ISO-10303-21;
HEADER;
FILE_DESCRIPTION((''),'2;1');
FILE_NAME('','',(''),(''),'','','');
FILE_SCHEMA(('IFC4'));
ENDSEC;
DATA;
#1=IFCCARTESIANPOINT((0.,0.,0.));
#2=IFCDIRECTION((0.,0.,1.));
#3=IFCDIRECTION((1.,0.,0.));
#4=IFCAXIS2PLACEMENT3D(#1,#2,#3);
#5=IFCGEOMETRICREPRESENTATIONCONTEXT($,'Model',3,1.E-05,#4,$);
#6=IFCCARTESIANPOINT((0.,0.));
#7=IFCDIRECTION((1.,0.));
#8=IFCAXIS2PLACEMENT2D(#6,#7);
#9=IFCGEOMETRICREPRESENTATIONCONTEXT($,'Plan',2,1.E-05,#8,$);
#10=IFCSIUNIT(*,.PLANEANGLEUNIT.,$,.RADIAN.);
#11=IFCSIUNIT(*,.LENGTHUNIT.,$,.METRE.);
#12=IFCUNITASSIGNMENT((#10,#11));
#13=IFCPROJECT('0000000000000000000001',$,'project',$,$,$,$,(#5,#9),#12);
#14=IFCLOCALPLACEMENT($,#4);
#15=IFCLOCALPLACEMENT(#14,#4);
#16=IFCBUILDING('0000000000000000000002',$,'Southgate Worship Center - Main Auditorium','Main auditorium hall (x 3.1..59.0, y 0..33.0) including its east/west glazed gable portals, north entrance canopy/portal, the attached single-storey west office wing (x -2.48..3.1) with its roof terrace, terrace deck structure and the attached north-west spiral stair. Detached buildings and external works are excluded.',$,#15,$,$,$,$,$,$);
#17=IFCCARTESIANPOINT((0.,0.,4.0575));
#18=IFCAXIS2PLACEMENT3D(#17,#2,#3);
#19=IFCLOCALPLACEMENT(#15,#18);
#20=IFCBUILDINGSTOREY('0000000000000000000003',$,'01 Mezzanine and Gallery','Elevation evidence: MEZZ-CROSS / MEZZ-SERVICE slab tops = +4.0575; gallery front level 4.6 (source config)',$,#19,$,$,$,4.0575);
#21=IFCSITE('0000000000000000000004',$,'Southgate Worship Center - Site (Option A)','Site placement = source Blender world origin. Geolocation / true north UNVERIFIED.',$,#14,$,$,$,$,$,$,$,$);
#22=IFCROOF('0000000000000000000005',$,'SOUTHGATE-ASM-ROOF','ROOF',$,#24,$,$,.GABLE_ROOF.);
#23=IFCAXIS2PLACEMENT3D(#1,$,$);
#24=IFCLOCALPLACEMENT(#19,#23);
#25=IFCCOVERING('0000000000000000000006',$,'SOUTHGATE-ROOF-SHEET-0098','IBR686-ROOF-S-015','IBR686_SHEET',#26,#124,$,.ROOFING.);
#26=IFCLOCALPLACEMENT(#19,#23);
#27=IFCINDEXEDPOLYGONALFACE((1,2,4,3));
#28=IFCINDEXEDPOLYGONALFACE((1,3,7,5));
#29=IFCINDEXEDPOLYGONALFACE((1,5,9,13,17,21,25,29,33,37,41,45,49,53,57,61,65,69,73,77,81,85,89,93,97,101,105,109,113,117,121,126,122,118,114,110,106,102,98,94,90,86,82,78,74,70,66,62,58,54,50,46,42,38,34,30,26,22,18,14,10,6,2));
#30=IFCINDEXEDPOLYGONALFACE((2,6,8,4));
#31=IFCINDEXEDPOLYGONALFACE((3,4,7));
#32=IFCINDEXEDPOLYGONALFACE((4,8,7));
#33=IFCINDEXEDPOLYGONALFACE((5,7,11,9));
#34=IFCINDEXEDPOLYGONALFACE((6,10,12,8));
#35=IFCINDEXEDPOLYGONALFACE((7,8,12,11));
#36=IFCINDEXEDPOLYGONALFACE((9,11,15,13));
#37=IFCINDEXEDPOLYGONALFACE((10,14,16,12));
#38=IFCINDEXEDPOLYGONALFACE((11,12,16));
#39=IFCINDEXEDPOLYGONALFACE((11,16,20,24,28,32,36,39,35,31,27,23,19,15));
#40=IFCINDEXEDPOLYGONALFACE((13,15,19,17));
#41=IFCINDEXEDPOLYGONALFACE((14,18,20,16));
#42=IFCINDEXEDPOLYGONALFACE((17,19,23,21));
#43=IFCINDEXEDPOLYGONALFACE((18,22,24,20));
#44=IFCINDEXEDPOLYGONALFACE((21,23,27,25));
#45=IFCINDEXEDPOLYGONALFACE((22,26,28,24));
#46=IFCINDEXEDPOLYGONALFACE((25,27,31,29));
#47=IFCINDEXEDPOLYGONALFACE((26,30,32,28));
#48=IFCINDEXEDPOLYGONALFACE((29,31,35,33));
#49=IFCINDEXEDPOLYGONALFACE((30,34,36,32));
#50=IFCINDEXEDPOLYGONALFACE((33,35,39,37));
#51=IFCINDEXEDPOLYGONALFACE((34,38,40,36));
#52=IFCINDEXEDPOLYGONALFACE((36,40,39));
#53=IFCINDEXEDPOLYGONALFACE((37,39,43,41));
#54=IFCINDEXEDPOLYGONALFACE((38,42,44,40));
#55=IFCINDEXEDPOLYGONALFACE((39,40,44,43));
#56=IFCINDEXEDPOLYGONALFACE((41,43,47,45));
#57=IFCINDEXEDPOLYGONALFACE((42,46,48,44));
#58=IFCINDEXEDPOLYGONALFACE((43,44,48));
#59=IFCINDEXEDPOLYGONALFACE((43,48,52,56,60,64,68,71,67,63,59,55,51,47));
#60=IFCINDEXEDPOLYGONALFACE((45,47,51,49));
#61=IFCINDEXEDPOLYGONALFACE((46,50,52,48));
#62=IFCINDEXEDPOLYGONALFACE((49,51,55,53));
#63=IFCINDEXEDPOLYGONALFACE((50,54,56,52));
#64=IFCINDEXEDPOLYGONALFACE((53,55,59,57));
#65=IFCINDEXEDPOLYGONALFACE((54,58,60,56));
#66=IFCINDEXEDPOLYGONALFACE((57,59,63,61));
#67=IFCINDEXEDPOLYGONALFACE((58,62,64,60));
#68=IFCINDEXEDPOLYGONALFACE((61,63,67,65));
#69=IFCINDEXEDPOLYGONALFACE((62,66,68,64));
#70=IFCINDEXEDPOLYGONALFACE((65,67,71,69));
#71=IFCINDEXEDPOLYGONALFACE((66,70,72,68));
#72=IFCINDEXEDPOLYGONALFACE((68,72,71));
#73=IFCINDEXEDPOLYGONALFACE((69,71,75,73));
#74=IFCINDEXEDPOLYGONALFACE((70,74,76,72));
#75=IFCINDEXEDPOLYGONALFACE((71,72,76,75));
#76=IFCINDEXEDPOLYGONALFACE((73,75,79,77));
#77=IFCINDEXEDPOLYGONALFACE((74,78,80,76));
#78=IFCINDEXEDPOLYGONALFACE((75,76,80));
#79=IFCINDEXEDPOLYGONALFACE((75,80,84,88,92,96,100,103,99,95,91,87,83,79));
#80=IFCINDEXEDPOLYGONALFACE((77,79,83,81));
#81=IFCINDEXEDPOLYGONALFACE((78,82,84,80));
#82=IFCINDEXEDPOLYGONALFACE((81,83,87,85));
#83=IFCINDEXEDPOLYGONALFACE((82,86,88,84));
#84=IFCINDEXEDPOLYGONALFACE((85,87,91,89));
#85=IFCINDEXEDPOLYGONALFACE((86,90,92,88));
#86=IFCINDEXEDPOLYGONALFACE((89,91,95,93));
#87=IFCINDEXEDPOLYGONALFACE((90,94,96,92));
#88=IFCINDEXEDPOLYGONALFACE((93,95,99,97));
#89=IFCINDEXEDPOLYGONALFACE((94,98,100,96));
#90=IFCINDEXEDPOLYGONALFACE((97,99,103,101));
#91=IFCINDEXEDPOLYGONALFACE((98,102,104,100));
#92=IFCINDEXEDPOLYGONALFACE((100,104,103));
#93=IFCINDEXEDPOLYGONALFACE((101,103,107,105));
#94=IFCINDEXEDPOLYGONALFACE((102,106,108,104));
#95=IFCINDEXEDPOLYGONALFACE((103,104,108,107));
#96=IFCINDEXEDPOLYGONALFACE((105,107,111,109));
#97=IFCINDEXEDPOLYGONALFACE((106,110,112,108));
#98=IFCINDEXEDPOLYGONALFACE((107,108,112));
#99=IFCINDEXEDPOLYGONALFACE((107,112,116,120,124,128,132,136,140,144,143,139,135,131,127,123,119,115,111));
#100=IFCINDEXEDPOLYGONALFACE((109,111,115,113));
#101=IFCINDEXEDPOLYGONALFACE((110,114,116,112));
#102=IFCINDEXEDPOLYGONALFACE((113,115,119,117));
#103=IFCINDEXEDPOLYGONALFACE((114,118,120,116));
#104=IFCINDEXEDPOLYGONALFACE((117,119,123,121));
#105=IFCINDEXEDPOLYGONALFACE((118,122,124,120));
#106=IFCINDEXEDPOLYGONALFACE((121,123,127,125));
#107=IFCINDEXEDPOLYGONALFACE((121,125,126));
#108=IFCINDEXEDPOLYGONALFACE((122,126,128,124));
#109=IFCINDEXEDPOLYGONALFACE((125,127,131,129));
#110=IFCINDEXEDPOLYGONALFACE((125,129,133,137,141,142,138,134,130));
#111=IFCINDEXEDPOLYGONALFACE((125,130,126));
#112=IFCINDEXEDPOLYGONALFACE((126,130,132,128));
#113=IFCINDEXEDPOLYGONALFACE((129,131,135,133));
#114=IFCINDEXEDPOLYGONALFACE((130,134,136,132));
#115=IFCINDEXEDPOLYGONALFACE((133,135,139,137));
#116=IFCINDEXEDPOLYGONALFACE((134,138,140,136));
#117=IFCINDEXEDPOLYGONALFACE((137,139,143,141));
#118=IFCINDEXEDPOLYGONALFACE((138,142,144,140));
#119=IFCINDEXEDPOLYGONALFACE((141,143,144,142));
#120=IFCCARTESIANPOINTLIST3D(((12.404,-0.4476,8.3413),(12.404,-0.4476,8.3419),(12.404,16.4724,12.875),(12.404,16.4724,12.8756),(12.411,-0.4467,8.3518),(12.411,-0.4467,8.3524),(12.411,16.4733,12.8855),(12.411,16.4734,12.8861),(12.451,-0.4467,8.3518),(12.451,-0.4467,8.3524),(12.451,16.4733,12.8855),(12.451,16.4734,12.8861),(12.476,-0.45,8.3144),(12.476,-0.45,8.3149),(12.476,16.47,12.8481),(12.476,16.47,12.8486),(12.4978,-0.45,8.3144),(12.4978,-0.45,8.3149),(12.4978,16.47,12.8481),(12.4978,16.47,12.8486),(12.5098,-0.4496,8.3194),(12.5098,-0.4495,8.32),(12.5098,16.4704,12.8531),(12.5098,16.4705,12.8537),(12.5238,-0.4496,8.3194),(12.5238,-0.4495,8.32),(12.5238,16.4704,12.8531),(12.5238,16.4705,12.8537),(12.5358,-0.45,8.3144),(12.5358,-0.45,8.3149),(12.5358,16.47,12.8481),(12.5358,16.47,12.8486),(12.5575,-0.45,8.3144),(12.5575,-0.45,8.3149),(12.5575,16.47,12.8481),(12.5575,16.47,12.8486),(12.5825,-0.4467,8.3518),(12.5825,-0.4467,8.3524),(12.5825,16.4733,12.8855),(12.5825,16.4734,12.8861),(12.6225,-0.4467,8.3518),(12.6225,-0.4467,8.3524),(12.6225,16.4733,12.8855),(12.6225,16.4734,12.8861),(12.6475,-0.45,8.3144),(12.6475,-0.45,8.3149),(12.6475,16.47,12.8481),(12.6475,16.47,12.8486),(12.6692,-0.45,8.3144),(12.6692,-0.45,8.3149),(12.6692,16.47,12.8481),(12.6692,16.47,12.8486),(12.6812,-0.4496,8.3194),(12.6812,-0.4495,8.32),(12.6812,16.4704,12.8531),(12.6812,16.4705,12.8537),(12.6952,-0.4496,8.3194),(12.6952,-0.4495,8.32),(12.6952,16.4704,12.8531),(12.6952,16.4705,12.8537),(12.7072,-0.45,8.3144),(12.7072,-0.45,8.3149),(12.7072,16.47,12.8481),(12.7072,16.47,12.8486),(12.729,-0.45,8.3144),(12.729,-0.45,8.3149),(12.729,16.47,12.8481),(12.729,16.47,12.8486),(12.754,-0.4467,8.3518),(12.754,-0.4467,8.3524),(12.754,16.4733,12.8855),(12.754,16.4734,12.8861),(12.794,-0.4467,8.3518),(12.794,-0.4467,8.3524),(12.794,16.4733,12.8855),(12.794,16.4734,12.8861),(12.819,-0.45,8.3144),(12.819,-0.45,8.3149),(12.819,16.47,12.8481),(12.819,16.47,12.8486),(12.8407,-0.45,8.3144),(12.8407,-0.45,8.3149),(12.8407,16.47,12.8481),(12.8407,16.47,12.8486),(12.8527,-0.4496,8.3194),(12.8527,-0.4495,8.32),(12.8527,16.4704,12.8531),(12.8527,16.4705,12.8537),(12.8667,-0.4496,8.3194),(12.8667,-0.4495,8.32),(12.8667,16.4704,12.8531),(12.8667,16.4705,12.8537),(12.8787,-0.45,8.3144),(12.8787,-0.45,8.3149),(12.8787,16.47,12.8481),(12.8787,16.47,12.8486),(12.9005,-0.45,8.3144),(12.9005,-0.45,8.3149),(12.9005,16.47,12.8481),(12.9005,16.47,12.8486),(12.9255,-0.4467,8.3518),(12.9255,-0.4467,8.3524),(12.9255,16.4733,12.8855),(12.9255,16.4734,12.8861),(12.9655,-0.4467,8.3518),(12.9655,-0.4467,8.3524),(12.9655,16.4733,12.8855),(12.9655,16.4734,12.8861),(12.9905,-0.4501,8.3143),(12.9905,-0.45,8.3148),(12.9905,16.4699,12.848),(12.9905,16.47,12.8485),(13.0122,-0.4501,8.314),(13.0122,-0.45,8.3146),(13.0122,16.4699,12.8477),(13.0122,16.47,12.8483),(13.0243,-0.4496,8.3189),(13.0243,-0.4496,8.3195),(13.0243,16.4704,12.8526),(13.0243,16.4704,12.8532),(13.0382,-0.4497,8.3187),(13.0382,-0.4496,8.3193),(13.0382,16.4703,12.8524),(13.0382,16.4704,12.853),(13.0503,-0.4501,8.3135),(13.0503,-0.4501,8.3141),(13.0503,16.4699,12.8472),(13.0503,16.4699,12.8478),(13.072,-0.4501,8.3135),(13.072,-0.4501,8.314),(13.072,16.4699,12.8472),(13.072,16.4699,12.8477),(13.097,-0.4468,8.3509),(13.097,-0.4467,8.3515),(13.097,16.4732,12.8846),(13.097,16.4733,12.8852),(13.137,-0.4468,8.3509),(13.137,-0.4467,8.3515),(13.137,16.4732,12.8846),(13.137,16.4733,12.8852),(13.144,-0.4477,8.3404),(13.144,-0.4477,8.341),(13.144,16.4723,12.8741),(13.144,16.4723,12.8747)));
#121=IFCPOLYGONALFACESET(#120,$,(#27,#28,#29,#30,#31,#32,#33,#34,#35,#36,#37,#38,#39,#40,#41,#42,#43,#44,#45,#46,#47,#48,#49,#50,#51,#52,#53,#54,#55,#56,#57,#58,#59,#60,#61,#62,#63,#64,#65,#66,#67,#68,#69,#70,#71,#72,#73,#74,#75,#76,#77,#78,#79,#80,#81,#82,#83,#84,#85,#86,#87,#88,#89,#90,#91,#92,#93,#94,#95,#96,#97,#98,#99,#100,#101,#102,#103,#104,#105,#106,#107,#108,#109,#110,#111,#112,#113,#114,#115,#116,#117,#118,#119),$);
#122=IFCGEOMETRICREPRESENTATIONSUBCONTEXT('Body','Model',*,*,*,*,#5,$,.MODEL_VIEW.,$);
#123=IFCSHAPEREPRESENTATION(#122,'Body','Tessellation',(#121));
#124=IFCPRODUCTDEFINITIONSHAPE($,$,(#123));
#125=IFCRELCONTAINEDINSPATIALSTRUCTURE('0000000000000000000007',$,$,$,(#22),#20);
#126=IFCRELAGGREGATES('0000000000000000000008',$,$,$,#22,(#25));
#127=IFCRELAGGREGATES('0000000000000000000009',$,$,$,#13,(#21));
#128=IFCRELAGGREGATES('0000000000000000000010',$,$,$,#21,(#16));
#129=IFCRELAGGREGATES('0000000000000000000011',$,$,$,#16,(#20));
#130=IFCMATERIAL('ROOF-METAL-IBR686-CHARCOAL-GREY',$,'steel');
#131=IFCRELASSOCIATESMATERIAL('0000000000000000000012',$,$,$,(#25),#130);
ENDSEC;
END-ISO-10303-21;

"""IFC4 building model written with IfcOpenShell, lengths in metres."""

from ifc_helpers import new_model, si_unit, frame, origin_with_axes, origin_2d_with_axis, place, context, subcontext, project, spatial, indexed_curve, outline, extrude, clip, halfspace, material, element, aggregate, save


model = new_model("IFC4")

# Units and contexts
model_context = context("Model", 3, precision=1e-05, world=origin_with_axes())
plan_context = context("Plan", 2, precision=1e-05, world=origin_2d_with_axis())
body_context = subcontext(model_context, "Body", "Model", "MODEL_VIEW")
ifc_project = project(units=[si_unit("PLANEANGLEUNIT", "RADIAN"), si_unit("LENGTHUNIT", "METRE")], contexts=[model_context, plan_context])

# Site, building, storey
site_placement = place(None, origin_with_axes())
site = spatial("IfcSite", under=ifc_project, at=site_placement, Name="Southgate Worship Center - Site (Option A)", Description="Site placement = source Blender world origin. Geolocation / true north UNVERIFIED.")
building_placement = place(site_placement, origin_with_axes())
building = spatial("IfcBuilding", under=site, at=building_placement, Name="Southgate Worship Center - Main Auditorium", Description="Main auditorium hall (x 3.1..59.0, y 0..33.0) including its east/west glazed gable portals, north entrance canopy/portal, the attached single-storey west office wing (x -2.48..3.1) with its roof terrace, terrace deck structure and the attached north-west spiral stair. Detached buildings and external works are excluded.")
storey_placement = place(building_placement, frame((0.0, 0.0, 4.0575), z_axis=(0.0, 0.0, 1.0), x_axis=(1.0, 0.0, 0.0)))
storey = spatial("IfcBuildingStorey", under=building, at=storey_placement, Name="01 Mezzanine and Gallery", Description="Elevation evidence: MEZZ-CROSS / MEZZ-SERVICE slab tops = +4.0575; gallery front level 4.6 (source config)", Elevation=4.0575)

# Roof, covering
roof_placement = place(storey_placement, origin_with_axes())
roof = element("IfcRoof", 1, at=roof_placement, inside=storey, Name="SOUTHGATE-ASM-ROOF", Description="ROOF", PredefinedType="GABLE_ROOF")
ifc_material_1 = material(Name="ROOF-METAL-IBR686-CHARCOAL-GREY", Category="steel")
covering_1_placement = place(roof_placement, frame((12.404, -0.4501, 8.3135), z_axis=(0.0, 0.0, 1.0), x_axis=(1.0, 0.0, 0.0)))
covering_1 = element("IfcCovering", 2, at=covering_1_placement, material=ifc_material_1, Name="SOUTHGATE-ROOF-SHEET-0098", Description="IBR686-ROOF-S-015", ObjectType="IBR686_SHEET", PredefinedType="ROOFING", context=body_context, shape_type="Clipping", body=[
    clip(clip(extrude(outline(indexed_curve([(0.0, 0.0), (0.025, 0.0353), (0.065, 0.0353), (0.072, 0.0254), (0.072, 0.0259), (0.065, 0.0358), (0.025, 0.0358), (0.0, 0.0005), (-0.0218, 0.0005), (-0.0338, 0.0053), (-0.0478, 0.0053), (-0.0598, 0.0005), (-0.0815, 0.0005), (-0.1065, 0.0358), (-0.1465, 0.0358), (-0.1715, 0.0005), (-0.1932, 0.0005), (-0.2052, 0.0053), (-0.2192, 0.0053), (-0.2312, 0.0005), (-0.253, 0.0005), (-0.278, 0.0358), (-0.318, 0.0358), (-0.343, 0.0005), (-0.3647, 0.0005), (-0.3767, 0.0053), (-0.3907, 0.0053), (-0.4028, 0.0005), (-0.4245, 0.0005), (-0.4495, 0.0358), (-0.4895, 0.0358), (-0.5145, 0.0004), (-0.5363, 0.0002), (-0.5483, 0.0048), (-0.5623, 0.0046), (-0.5743, -0.0003), (-0.596, -0.0004), (-0.621, 0.0349), (-0.661, 0.0349), (-0.668, 0.0251), (-0.668, 0.0246), (-0.661, 0.0344), (-0.621, 0.0344), (-0.596, -0.0009), (-0.5743, -0.0008), (-0.5623, 0.0041), (-0.5483, 0.0043), (-0.5363, -0.0003), (-0.5145, -0.0001), (-0.4895, 0.0353), (-0.4495, 0.0353), (-0.4245, 0.0), (-0.4028, 0.0), (-0.3907, 0.0048), (-0.3767, 0.0048), (-0.3647, 0.0), (-0.343, 0.0), (-0.318, 0.0353), (-0.278, 0.0353), (-0.253, 0.0), (-0.2312, 0.0), (-0.2192, 0.0048), (-0.2052, 0.0048), (-0.1932, 0.0), (-0.1715, 0.0), (-0.1465, 0.0353), (-0.1065, 0.0353), (-0.0815, 0.0), (-0.0598, 0.0), (-0.0478, 0.0048), (-0.0338, 0.0048), (-0.0218, 0.0), (0.0, 0.0)], self_intersect=False)), frame((0.072, -0.0003, 0.0008), z_axis=(0.0, 0.965926, 0.258819), x_axis=(-1.0, 0.0, 0.0)), (0.0, 0.0, 1.0), 17.5303), halfspace(frame((0.37, 0.0012, 0.014), z_axis=(0.0, -0.996022, 0.089113), x_axis=(1.0, 0.0, 0.0)), False)), halfspace(frame((0.37, 16.9212, 4.5477), z_axis=(0.0, 0.996021, -0.089119), x_axis=(-1.0, 0.0, 0.0)), False)),
])
aggregate(roof, [covering_1])

save(model, "model.ifc")
